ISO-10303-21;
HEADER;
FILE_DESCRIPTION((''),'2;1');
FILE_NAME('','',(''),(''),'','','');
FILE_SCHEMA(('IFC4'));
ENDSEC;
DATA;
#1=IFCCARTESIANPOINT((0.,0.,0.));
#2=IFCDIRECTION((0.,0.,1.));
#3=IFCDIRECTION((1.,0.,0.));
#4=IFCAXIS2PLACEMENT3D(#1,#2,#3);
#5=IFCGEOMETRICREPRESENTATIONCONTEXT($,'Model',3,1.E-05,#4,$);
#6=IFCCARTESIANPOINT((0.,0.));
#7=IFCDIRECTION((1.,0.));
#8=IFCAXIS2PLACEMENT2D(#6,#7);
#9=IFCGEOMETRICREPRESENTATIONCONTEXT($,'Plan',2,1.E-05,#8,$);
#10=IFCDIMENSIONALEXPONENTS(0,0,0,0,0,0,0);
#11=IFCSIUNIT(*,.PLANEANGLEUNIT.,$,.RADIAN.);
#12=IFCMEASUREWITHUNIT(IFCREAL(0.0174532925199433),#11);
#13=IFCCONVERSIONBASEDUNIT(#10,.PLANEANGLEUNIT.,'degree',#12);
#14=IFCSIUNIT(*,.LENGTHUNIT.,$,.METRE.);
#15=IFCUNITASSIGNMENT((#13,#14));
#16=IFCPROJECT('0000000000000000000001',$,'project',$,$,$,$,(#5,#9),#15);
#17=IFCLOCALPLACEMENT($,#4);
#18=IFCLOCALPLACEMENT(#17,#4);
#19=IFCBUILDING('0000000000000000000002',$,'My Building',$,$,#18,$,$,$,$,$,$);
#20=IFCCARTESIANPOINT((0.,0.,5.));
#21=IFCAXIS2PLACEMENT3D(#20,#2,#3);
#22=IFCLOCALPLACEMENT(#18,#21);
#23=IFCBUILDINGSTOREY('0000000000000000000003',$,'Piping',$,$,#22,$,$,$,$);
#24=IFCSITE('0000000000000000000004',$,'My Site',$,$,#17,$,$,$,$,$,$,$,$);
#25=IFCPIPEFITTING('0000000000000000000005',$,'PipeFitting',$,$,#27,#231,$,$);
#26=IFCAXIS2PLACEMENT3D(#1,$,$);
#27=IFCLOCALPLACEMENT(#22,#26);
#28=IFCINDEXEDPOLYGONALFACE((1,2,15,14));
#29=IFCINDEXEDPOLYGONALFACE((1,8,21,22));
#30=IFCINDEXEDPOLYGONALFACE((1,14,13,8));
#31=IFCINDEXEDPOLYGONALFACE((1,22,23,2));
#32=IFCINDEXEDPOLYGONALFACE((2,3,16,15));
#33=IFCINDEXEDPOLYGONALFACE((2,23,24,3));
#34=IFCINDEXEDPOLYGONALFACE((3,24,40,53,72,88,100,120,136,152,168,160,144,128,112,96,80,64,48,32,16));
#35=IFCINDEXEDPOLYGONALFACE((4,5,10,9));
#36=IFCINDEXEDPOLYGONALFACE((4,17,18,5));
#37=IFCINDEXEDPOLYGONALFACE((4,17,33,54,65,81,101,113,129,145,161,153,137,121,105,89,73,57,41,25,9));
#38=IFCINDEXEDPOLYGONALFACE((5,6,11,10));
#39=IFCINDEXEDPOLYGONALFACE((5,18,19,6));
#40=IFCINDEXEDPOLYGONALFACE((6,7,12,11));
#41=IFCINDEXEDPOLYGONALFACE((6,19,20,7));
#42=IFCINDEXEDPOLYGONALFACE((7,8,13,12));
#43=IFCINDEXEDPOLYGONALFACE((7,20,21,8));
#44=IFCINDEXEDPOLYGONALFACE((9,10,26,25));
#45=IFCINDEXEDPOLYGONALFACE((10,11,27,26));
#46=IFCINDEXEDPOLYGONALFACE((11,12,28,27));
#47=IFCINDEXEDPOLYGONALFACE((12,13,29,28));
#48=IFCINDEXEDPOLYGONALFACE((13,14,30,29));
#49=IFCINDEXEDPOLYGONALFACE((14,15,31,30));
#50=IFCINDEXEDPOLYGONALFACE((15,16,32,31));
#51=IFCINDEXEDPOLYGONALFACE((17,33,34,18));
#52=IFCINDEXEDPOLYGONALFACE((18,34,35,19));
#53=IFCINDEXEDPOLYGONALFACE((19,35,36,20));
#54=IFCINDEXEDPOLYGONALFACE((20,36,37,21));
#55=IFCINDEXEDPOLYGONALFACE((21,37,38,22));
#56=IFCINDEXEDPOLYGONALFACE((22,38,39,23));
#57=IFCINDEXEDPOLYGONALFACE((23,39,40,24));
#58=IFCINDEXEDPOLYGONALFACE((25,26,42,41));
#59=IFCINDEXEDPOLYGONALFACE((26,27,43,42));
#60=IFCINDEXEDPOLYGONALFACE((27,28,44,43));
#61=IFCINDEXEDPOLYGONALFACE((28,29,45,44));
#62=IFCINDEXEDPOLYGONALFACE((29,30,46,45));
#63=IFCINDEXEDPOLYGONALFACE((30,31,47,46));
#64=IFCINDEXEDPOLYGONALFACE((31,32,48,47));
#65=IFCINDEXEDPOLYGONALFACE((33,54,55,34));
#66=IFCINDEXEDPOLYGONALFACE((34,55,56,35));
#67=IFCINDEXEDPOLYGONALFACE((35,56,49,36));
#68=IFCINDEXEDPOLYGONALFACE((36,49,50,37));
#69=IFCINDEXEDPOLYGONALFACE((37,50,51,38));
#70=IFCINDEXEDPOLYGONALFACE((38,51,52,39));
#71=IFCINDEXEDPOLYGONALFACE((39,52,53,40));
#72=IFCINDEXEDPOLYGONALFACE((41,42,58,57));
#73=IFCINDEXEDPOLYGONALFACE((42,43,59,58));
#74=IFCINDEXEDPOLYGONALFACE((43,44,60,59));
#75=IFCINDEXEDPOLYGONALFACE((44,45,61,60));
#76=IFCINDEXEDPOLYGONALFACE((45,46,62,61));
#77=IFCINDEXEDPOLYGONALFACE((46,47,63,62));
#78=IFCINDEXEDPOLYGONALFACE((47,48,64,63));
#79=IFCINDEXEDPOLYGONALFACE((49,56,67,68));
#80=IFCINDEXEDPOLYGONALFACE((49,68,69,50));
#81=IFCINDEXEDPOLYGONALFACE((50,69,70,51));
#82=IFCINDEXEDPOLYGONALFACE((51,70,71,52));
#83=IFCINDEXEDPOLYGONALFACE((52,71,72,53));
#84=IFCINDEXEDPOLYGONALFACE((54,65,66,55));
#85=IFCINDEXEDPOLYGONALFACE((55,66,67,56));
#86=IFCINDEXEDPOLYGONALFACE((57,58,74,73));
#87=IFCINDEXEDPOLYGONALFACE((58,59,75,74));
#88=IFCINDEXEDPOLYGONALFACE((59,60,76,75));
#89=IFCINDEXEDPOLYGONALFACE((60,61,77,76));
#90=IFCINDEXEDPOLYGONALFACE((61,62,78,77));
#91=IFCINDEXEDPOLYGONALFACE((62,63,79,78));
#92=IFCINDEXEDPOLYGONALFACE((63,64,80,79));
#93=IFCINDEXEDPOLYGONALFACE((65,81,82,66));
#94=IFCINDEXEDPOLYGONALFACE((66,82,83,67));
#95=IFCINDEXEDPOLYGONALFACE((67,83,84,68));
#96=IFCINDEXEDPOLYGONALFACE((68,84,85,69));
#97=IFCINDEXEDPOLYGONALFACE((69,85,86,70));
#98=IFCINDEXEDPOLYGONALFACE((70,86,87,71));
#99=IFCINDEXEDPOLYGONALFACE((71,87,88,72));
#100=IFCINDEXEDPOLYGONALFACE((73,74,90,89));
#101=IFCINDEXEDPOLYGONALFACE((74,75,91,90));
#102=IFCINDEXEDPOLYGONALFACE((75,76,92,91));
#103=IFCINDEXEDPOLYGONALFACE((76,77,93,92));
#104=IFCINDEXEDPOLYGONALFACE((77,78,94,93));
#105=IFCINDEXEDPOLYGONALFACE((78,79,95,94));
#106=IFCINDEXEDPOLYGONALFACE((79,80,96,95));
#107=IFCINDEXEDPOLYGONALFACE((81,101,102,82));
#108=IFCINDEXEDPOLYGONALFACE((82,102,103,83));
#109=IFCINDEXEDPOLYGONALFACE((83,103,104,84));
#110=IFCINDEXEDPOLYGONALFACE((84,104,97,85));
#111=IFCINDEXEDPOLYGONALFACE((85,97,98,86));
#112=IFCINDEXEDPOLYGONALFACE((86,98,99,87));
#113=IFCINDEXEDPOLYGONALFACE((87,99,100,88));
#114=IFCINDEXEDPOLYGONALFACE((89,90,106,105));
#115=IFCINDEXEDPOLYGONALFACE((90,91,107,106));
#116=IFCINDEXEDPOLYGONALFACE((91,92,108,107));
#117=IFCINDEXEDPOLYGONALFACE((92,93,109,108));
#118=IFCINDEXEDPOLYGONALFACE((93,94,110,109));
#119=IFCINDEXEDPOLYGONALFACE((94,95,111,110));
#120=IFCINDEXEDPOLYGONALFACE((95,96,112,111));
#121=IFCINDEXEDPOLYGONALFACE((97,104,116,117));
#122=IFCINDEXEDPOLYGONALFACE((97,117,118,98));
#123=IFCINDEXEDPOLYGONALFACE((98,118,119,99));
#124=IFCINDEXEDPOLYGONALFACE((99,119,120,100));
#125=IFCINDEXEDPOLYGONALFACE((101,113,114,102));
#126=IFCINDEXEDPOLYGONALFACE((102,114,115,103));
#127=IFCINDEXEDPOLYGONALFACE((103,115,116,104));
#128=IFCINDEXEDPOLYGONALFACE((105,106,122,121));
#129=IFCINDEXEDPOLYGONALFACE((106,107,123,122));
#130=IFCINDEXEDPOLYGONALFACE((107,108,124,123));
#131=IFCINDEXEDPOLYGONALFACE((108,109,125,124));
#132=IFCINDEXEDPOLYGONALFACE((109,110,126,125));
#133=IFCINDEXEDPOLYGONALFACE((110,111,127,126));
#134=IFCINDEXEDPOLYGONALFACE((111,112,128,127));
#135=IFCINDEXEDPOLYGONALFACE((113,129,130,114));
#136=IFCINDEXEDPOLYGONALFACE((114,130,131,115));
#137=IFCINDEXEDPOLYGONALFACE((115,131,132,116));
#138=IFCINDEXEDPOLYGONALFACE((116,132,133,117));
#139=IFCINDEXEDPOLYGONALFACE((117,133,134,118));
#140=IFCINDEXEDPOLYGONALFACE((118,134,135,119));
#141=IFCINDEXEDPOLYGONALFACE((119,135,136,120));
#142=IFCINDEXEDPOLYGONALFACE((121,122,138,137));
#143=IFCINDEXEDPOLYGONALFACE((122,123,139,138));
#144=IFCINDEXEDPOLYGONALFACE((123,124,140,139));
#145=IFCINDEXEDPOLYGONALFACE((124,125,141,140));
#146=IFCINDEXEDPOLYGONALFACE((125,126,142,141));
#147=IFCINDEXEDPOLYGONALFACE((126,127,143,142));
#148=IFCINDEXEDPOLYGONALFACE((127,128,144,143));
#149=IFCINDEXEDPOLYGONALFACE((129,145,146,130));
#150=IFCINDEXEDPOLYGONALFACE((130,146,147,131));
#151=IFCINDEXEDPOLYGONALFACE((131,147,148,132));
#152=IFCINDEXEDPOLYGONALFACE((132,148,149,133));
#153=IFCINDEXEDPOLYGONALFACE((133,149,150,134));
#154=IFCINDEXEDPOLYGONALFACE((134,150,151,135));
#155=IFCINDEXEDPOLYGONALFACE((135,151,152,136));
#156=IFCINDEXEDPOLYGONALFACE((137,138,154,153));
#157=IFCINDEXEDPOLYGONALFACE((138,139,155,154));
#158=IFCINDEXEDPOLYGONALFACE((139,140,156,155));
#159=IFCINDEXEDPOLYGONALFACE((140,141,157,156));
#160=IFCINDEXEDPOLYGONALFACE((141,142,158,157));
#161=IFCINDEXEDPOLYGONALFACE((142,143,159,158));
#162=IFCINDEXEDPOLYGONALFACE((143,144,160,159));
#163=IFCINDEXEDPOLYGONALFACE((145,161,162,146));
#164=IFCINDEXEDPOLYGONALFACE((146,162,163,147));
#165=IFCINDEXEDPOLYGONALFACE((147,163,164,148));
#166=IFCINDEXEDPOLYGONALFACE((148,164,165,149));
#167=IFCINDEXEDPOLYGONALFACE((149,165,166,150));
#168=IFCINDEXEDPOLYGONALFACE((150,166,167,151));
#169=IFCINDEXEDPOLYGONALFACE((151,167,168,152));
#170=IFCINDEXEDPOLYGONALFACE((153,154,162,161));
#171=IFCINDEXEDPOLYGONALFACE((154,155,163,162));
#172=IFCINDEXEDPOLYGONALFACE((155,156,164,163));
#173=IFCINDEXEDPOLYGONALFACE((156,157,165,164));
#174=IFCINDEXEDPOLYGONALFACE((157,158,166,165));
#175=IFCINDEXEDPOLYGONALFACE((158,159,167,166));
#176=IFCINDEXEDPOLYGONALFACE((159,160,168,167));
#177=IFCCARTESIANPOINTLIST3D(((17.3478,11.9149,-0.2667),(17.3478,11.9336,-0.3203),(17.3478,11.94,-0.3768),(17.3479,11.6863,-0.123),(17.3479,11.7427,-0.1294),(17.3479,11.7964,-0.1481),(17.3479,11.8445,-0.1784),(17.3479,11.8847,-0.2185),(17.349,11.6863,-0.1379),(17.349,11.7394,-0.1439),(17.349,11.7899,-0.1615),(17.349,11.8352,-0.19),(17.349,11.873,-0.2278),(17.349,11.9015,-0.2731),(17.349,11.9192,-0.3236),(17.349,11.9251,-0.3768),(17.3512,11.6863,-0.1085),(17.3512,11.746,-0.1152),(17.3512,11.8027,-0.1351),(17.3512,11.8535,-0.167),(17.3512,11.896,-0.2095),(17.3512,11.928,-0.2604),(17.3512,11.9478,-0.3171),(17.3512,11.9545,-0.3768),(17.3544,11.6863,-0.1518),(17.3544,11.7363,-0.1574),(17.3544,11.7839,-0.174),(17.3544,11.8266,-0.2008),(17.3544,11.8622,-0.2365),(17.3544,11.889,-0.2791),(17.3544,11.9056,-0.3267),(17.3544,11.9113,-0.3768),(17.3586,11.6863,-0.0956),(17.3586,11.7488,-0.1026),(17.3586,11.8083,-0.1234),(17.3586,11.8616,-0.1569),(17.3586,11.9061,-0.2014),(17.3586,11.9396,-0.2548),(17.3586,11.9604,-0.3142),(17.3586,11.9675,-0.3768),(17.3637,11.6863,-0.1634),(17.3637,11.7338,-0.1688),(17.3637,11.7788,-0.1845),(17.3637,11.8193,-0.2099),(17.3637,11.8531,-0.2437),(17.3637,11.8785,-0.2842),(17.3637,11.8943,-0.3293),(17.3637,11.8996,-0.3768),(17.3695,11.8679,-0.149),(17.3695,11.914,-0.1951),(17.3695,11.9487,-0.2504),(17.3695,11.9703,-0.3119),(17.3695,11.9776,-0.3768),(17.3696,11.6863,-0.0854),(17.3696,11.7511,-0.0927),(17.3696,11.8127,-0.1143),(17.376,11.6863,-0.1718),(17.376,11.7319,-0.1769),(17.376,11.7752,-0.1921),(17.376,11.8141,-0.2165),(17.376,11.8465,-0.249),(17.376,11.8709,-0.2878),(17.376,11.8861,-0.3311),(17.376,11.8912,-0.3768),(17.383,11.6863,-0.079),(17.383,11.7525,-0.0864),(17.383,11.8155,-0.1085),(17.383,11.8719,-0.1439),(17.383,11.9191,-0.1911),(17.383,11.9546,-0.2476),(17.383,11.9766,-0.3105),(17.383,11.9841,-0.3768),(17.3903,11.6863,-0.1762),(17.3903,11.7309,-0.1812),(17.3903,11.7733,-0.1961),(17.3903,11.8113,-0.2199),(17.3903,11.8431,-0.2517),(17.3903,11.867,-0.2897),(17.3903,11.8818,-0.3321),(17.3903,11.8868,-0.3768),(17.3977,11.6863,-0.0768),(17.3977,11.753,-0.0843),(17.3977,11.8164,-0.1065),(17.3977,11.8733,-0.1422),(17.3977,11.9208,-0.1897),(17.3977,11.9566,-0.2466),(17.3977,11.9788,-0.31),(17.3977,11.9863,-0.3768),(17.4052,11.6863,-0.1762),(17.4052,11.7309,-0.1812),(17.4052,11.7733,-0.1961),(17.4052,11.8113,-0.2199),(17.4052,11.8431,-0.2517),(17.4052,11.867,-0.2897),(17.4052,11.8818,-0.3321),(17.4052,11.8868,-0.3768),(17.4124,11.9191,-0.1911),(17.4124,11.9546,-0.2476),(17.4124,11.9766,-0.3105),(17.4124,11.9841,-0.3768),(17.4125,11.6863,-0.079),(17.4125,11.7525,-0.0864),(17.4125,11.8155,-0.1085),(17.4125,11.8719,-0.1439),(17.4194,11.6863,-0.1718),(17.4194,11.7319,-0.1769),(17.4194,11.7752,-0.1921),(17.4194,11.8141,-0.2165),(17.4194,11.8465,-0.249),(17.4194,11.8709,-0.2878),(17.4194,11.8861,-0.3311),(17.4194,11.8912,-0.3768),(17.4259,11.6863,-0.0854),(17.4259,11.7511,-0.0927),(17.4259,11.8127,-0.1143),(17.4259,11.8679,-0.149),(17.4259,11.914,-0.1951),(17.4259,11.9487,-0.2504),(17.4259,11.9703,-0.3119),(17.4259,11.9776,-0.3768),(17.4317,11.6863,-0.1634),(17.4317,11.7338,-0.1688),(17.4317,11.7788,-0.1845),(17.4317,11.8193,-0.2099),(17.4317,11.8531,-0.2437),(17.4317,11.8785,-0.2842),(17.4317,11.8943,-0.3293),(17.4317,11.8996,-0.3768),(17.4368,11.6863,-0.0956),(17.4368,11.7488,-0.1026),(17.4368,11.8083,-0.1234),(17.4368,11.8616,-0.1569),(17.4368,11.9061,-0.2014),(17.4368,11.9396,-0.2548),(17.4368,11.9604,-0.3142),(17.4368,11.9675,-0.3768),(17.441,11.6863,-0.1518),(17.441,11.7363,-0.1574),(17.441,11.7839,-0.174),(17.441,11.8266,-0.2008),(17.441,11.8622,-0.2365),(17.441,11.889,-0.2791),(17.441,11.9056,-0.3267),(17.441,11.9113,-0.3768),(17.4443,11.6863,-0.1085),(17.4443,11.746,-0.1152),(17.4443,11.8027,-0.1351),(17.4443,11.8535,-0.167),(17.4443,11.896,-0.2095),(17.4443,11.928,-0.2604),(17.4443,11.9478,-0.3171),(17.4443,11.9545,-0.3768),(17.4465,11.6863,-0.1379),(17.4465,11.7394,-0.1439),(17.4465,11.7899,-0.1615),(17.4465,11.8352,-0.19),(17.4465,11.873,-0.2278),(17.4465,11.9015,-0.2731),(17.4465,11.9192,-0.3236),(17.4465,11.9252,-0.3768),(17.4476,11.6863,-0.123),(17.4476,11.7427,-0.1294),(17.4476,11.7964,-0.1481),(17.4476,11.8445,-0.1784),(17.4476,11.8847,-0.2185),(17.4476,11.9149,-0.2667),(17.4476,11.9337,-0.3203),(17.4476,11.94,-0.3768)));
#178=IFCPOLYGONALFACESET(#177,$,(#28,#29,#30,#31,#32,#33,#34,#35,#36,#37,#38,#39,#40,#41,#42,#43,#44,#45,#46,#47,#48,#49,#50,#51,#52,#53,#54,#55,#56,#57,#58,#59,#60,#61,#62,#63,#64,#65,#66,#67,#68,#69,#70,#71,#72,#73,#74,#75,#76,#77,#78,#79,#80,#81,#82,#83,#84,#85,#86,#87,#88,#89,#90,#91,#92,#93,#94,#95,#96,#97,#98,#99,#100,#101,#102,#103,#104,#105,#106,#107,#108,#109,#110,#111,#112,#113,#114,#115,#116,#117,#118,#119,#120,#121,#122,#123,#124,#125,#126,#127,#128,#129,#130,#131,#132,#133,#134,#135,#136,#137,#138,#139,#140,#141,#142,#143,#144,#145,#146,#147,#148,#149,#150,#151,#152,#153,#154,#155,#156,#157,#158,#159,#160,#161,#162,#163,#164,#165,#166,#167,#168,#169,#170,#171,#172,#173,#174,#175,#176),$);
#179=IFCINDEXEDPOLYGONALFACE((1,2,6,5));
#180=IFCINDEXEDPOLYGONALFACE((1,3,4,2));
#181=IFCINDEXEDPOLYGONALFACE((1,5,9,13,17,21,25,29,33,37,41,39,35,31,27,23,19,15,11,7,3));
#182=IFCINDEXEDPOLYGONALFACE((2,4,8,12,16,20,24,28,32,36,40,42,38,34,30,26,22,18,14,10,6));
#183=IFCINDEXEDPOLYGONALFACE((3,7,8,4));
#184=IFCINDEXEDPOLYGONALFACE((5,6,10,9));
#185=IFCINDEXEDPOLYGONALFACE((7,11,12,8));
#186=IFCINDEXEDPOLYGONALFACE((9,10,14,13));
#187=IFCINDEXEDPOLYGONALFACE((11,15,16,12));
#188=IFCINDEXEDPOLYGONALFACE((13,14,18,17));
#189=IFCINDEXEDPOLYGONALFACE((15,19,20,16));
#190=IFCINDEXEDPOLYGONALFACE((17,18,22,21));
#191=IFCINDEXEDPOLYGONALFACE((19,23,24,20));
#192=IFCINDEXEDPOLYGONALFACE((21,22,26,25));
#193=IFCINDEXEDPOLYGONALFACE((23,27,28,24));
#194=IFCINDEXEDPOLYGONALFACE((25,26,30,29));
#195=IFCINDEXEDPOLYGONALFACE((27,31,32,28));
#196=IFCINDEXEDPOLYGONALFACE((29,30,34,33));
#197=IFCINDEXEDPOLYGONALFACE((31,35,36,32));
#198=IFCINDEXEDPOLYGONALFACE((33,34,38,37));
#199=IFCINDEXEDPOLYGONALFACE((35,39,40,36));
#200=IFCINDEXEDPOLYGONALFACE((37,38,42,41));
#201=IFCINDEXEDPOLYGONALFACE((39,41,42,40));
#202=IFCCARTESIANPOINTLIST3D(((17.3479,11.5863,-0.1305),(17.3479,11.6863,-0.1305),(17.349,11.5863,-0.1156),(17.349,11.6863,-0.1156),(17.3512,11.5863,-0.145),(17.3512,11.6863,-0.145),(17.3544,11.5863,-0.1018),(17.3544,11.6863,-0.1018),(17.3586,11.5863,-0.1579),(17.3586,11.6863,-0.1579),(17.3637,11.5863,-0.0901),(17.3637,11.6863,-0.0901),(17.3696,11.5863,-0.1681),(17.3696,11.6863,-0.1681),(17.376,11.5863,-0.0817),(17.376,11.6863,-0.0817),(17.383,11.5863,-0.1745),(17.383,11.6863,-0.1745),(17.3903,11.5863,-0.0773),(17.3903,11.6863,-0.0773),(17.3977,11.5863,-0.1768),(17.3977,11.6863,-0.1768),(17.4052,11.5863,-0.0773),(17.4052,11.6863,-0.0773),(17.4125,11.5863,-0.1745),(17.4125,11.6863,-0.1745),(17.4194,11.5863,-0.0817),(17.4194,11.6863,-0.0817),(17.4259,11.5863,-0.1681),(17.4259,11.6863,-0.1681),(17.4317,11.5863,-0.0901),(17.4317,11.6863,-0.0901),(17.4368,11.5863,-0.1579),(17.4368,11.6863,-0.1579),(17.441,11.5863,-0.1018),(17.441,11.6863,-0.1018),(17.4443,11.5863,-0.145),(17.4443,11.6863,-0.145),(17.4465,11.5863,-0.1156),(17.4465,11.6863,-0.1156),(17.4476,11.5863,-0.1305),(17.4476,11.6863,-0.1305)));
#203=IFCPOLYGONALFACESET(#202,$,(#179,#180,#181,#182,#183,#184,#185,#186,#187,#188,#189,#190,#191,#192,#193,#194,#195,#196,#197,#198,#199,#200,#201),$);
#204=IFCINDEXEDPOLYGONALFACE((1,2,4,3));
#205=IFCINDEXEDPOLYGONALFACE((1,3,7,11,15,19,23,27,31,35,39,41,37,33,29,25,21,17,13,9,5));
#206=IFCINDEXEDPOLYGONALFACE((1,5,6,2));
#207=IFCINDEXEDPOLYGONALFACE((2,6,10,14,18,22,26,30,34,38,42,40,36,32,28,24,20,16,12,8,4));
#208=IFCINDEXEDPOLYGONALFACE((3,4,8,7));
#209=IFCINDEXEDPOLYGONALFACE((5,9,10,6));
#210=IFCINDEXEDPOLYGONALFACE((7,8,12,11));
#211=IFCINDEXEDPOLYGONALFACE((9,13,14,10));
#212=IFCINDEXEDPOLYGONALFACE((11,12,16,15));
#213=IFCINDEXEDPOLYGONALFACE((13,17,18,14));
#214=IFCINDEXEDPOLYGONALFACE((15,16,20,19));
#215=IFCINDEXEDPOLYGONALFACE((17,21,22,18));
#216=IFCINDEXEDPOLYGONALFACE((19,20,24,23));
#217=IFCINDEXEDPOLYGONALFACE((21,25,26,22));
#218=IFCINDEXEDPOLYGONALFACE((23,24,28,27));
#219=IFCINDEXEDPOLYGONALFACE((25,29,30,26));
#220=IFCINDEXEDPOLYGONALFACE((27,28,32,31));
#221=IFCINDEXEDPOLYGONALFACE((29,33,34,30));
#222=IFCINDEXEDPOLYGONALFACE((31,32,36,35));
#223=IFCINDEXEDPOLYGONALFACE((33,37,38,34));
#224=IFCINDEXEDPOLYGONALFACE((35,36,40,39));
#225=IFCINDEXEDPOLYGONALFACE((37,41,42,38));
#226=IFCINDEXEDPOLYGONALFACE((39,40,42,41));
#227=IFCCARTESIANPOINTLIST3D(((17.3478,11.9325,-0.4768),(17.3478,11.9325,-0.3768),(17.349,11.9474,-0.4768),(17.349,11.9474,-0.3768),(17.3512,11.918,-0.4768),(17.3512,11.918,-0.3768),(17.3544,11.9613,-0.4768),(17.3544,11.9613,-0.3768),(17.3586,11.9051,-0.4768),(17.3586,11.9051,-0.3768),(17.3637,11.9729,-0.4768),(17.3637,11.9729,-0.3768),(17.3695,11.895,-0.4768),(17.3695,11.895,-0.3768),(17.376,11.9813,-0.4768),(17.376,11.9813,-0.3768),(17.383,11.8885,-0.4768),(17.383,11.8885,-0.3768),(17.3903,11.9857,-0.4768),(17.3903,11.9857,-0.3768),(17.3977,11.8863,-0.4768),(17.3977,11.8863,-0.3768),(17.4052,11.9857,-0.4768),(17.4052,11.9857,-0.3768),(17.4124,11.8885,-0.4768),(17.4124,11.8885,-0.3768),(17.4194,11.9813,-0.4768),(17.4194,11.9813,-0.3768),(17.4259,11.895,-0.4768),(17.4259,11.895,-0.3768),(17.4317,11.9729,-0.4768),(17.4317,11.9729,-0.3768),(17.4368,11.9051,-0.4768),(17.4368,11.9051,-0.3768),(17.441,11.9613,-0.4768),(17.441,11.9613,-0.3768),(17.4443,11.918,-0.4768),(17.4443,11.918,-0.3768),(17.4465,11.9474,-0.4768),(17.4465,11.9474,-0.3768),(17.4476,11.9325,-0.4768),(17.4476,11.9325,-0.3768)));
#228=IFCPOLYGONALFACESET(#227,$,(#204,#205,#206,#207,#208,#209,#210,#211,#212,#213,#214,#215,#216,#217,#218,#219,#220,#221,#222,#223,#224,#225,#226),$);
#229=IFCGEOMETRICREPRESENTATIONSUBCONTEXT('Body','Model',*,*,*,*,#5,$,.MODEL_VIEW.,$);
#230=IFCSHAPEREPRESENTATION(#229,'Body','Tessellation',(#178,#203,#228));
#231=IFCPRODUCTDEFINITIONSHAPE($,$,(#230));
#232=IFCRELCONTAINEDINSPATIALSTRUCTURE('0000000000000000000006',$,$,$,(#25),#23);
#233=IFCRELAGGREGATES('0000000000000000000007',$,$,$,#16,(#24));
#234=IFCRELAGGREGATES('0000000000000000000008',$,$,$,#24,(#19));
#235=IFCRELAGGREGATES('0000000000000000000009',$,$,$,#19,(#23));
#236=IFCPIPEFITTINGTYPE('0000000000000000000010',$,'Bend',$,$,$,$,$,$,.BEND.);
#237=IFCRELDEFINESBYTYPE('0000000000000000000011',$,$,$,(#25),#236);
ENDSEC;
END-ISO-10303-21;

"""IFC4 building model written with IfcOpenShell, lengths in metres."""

from ifc_helpers import new_model, entity, si_unit, converted_unit, frame, origin_with_axes, origin_2d_with_axis, place, context, subcontext, project, spatial, circle, extrude, source, transform, mapped, type_object, type_shapes, element, save


model = new_model("IFC4")

# Units and contexts
model_context = context("Model", 3, precision=1e-05, world=origin_with_axes())
plan_context = context("Plan", 2, precision=1e-05, world=origin_2d_with_axis())
body_context = subcontext(model_context, "Body", "Model", "MODEL_VIEW")
ifc_project = project(units=[converted_unit("PLANEANGLEUNIT", "degree", entity("IfcReal", 0.0174532925199433), si_unit("PLANEANGLEUNIT", "RADIAN"), dimensions=[0, 0, 0, 0, 0, 0, 0]), si_unit("LENGTHUNIT", "METRE")], contexts=[model_context, plan_context])

# Site, building, storey
site_placement = place(None, origin_with_axes())
site = spatial("IfcSite", under=ifc_project, at=site_placement, Name="My Site")
building_placement = place(site_placement, origin_with_axes())
building = spatial("IfcBuilding", under=site, at=building_placement, Name="My Building")
storey_placement = place(building_placement, frame((0.0, 0.0, 5.0), z_axis=(0.0, 0.0, 1.0), x_axis=(1.0, 0.0, 0.0)))
storey = spatial("IfcBuildingStorey", under=building, at=storey_placement, Name="Piping")

# Pipe fitting
pipe_fitting_type_1 = type_object("IfcPipeFittingType", Name="Bend", PredefinedType="BEND")
shared_shape = source(origin_with_axes(), body_context, "Body", "SolidModel", [
    entity("IfcSweptDiskSolid", entity("IfcIndexedPolyCurve", entity("IfcCartesianPointList3D", [[0.0, 0.0, -0.1], [0.0732, 0.0, -0.2768], [0.25, 0.0, -0.35]]), [entity("IfcArcIndex", [1, 2, 3])]), 0.05),
    extrude(circle(Radius=0.05), origin_with_axes(), (0.0, 0.0, -1.0), 0.1),
    extrude(circle(Radius=0.05), frame((0.25, 0.0, -0.35), z_axis=(1.0, 0.0, 0.0), x_axis=(0.0, 0.0, 1.0)), (0.0, 0.0, 1.0), 0.1),
])
type_shapes(pipe_fitting_type_1, [shared_shape])
for number, where, z_axis, x_axis, name in (
    (1, (17.3977, 11.5863, -0.1268), (0.00006, -1.0, 0.0), (0.0, 0.0, -1.0), "PipeFitting"),
):
    element("IfcPipeFitting", number, at=place(storey_placement, frame(where, z_axis=z_axis, x_axis=x_axis)), inside=storey, type_object=pipe_fitting_type_1, Name=name, context=body_context, shape_type="MappedRepresentation", body=[
        mapped(shared_shape, transform((0.0, 0.0, 0.0), x_axis=(1.0, 0.0, 0.0), y_axis=(0.0, 1.0, 0.0), z_axis=(0.0, 0.0, 1.0), scale=1.0)),
    ])

save(model, "model.ifc")
